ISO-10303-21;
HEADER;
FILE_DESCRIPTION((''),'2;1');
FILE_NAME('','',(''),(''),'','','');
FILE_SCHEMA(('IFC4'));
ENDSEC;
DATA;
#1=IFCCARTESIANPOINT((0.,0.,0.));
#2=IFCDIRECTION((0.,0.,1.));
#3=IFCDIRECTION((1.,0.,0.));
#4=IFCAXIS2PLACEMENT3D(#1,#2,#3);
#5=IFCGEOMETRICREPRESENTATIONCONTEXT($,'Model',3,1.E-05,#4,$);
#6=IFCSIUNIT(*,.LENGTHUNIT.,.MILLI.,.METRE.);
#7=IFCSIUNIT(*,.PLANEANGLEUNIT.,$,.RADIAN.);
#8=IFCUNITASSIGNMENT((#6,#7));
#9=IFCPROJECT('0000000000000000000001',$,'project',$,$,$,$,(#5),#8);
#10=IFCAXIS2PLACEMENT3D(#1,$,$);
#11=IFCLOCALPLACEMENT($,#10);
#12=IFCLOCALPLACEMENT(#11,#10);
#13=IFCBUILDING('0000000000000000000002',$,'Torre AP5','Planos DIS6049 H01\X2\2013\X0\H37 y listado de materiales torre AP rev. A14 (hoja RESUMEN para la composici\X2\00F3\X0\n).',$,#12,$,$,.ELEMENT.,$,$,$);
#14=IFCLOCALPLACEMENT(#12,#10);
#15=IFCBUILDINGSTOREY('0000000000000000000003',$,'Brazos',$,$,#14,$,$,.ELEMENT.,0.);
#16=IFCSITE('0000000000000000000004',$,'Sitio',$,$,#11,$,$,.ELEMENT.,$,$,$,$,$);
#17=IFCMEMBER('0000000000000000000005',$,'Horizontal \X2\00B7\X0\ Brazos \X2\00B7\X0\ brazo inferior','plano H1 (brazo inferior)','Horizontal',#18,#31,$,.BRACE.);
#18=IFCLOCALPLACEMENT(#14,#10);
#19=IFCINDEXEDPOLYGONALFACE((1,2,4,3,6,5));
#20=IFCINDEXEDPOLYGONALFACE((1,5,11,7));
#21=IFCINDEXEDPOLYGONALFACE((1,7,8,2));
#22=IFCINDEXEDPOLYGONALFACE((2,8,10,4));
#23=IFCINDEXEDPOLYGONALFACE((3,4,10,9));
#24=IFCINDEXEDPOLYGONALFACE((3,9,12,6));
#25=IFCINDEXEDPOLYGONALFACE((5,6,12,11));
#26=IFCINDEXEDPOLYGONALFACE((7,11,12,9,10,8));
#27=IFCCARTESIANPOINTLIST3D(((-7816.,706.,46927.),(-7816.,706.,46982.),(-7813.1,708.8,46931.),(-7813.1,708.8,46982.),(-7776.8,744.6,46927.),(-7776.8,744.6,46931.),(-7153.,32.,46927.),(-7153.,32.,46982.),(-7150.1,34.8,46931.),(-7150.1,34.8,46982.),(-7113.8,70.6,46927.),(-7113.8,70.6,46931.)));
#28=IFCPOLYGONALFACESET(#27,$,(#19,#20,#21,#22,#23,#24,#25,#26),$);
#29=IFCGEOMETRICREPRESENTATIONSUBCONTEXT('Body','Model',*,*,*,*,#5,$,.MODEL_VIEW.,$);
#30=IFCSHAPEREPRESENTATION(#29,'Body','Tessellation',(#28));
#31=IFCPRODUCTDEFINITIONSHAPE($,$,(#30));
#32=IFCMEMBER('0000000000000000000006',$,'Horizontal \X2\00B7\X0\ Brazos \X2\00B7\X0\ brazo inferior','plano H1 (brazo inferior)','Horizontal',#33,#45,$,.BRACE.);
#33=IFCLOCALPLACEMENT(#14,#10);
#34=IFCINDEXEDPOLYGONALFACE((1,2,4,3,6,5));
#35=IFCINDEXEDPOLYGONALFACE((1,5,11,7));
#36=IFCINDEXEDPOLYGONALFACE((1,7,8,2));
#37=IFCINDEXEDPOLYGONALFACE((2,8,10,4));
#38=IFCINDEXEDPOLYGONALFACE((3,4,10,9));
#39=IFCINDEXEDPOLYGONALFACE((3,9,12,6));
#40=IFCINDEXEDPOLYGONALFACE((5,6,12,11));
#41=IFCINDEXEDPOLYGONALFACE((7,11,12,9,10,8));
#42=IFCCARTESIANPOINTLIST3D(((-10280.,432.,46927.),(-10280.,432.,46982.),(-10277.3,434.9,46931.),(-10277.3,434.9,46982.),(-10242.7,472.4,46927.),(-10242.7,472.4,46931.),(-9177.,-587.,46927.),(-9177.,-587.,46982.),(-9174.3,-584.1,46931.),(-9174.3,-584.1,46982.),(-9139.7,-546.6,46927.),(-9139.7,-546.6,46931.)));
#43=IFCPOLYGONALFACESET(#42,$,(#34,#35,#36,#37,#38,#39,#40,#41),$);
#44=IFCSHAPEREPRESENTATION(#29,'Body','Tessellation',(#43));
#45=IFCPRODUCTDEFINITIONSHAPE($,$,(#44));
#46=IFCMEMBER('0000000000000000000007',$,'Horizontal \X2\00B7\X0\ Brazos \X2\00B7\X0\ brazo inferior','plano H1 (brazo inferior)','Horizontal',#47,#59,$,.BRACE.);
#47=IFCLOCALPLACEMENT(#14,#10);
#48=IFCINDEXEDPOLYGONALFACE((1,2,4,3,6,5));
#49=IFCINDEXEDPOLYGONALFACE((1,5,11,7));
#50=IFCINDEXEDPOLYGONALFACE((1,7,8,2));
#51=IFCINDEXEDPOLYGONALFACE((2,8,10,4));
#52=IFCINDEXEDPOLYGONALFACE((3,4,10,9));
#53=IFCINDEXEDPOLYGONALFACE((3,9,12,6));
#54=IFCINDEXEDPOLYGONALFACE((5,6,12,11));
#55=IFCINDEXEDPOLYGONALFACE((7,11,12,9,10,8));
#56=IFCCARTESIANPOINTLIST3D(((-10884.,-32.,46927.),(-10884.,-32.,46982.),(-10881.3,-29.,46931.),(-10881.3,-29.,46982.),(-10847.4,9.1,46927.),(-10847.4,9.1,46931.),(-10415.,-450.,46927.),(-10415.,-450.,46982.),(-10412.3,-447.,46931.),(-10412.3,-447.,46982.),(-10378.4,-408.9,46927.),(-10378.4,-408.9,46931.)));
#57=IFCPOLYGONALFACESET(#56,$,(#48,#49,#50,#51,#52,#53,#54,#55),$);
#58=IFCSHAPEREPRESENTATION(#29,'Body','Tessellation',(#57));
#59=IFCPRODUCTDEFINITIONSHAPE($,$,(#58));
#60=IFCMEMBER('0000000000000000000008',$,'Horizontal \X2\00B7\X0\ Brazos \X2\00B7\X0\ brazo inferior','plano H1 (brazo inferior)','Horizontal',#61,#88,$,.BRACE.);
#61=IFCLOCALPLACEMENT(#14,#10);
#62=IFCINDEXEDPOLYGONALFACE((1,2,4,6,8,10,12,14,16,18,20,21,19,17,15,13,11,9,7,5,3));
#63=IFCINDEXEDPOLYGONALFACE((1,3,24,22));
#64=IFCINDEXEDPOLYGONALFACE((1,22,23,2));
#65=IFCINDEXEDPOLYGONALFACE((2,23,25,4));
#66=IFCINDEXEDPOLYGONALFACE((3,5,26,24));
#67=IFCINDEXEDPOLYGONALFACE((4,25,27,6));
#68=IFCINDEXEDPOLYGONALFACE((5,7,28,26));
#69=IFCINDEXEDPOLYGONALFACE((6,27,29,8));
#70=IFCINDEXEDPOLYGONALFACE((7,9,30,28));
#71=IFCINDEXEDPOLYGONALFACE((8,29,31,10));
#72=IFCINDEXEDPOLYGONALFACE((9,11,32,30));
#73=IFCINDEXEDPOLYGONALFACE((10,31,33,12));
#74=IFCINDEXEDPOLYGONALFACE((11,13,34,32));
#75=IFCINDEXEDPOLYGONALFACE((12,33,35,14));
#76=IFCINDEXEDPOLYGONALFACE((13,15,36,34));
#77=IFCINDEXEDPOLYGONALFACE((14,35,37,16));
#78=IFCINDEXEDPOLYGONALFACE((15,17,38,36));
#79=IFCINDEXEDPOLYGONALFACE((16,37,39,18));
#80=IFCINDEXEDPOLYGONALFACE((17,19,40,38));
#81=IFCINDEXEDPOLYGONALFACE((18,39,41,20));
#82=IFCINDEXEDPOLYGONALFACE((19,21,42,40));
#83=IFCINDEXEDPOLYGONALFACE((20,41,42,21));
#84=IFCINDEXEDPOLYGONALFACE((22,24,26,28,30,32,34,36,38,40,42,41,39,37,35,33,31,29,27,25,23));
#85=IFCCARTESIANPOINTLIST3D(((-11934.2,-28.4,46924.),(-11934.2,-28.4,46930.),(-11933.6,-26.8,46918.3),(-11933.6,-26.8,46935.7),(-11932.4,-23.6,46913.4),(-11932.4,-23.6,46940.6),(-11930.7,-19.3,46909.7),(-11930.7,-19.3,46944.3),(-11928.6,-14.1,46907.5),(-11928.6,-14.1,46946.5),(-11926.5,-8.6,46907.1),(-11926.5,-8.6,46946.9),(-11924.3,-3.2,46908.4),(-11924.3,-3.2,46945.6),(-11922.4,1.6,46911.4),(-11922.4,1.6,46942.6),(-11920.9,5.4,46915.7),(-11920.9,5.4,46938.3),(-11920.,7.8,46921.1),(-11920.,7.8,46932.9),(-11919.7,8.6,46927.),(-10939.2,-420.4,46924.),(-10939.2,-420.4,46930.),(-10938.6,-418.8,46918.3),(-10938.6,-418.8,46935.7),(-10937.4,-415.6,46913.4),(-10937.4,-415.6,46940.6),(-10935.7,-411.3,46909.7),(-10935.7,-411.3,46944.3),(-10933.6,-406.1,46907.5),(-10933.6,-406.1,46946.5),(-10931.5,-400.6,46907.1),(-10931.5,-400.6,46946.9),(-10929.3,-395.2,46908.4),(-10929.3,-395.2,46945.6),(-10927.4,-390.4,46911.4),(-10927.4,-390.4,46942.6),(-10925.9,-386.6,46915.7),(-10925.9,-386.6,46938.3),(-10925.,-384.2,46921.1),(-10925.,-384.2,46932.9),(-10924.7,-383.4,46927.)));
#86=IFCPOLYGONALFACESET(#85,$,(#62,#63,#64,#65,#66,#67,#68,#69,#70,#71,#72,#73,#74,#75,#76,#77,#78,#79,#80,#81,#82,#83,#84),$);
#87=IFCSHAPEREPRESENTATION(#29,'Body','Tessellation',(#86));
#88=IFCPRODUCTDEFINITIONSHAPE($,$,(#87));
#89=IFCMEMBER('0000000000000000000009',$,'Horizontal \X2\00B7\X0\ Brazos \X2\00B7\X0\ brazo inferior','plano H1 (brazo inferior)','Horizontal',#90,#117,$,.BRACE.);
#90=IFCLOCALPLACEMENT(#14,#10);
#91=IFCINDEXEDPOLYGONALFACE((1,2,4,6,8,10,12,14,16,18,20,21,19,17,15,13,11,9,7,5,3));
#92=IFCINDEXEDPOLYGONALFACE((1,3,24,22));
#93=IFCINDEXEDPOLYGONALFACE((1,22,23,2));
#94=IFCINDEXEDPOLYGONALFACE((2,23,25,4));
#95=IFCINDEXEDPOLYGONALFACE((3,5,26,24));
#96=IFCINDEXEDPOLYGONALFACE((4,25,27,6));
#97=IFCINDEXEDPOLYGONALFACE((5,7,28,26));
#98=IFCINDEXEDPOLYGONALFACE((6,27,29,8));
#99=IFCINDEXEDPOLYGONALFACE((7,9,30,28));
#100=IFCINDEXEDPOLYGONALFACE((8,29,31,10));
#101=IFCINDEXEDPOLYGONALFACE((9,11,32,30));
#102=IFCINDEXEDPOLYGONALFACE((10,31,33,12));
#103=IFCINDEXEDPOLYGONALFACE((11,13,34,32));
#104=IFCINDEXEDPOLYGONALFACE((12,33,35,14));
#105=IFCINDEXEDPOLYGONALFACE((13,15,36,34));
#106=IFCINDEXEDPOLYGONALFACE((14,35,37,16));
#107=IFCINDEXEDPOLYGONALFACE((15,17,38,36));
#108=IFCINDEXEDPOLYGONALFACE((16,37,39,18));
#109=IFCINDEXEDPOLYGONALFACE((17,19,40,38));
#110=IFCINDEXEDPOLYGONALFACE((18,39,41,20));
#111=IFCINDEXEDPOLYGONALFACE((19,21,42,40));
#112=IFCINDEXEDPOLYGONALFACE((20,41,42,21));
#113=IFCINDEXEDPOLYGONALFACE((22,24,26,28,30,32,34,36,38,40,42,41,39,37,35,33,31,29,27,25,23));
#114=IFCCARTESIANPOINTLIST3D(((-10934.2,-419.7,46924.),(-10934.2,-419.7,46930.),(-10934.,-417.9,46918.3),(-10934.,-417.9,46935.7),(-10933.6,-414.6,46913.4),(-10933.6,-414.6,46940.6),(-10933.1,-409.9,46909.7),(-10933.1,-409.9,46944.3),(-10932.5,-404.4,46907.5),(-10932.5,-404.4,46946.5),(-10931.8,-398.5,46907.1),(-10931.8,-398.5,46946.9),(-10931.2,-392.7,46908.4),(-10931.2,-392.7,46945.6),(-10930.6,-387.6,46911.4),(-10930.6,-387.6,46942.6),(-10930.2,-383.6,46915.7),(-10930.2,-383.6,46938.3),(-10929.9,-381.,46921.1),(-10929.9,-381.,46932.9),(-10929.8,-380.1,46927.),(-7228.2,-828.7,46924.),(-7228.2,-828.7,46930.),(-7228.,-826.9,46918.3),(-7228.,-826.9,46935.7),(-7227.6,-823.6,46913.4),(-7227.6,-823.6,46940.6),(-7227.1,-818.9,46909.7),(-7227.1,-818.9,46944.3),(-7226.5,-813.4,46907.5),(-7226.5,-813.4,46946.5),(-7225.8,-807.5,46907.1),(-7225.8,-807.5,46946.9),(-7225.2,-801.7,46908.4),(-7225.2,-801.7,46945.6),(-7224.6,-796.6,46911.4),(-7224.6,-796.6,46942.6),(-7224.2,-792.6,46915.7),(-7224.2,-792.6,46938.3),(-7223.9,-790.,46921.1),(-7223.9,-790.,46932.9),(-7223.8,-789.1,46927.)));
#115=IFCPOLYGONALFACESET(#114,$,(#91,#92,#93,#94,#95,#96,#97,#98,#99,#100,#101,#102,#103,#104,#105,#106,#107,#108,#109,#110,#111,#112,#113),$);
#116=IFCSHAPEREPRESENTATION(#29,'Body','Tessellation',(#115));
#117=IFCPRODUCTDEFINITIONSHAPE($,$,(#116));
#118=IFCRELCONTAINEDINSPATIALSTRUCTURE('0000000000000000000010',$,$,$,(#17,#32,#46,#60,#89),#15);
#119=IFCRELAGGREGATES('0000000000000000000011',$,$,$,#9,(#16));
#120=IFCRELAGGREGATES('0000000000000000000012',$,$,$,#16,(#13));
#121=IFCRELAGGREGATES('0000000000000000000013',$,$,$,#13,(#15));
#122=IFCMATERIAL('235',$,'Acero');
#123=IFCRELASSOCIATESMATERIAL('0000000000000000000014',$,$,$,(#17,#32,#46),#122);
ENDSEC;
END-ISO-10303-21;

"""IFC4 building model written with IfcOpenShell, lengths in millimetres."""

from ifc_helpers import new_model, si_unit, frame, frame_2d, origin, origin_with_axes, place, context, subcontext, project, spatial, circle, l_section, extrude, material, element, save


model = new_model("IFC4")

# Units and contexts
model_context = context("Model", 3, precision=1e-05, world=origin_with_axes())
body_context = subcontext(model_context, "Body", "Model", "MODEL_VIEW")
ifc_project = project(units=[si_unit("LENGTHUNIT", "METRE", prefix="MILLI"), si_unit("PLANEANGLEUNIT", "RADIAN")], contexts=[model_context])

# Site, building, storey
site_placement = place(None, origin())
site = spatial("IfcSite", under=ifc_project, at=site_placement, Name="Sitio", CompositionType="ELEMENT")
building_placement = place(site_placement, origin())
building = spatial("IfcBuilding", under=site, at=building_placement, Name="Torre AP5", Description="Planos DIS6049 H01–H37 y listado de materiales torre AP rev. A14 (hoja RESUMEN para la composición).", CompositionType="ELEMENT")
storey_placement = place(building_placement, origin())
storey = spatial("IfcBuildingStorey", under=building, at=storey_placement, Name="Brazos", CompositionType="ELEMENT", Elevation=0.0)

# Members
ifc_material_1 = material(Name="235", Category="Acero")
member_1_placement = place(storey_placement, frame((-7816.0, 706.0, 46927.0), z_axis=(0.701265, -0.7129, 0.0), x_axis=(0.7129, 0.701265, 0.0)))
element("IfcMember", 1, at=member_1_placement, inside=storey, material=ifc_material_1, Name="Horizontal · Brazos · brazo inferior", Description="plano H1 (brazo inferior)", ObjectType="Horizontal", PredefinedType="BRACE", context=body_context, shape_type="SweptSolid", body=[
    extrude(l_section(Depth=55.0, Width=55.0, Thickness=4.0, at=frame_2d((27.5, 27.5))), None, (0.0, 0.0, 1.0), 945.4),
])
member_2_placement = place(storey_placement, frame((-10280.0, 432.0, 46927.0), z_axis=(0.734523, -0.678584, 0.0), x_axis=(0.678584, 0.734523, 0.0)))
element("IfcMember", 2, at=member_2_placement, inside=storey, material=ifc_material_1, Name="Horizontal · Brazos · brazo inferior", Description="plano H1 (brazo inferior)", ObjectType="Horizontal", PredefinedType="BRACE", context=body_context, shape_type="SweptSolid", body=[
    extrude(l_section(Depth=55.0, Width=55.0, Thickness=4.0, at=frame_2d((27.5, 27.5))), None, (0.0, 0.0, 1.0), 1501.7),
])
member_3_placement = place(storey_placement, frame((-10884.0, -32.0, 46927.0), z_axis=(0.74653, -0.665351, 0.0), x_axis=(0.665351, 0.74653, 0.0)))
element("IfcMember", 3, at=member_3_placement, inside=storey, material=ifc_material_1, Name="Horizontal · Brazos · brazo inferior", Description="plano H1 (brazo inferior)", ObjectType="Horizontal", PredefinedType="BRACE", context=body_context, shape_type="SweptSolid", body=[
    extrude(l_section(Depth=55.0, Width=55.0, Thickness=4.0, at=frame_2d((27.5, 27.5))), None, (0.0, 0.0, 1.0), 628.2),
])
member_4_placement = place(storey_placement, frame((-11927.0, -10.0, 46927.0), z_axis=(0.930399, -0.366549, 0.0), x_axis=(0.366549, 0.930399, 0.0)))
element("IfcMember", 4, at=member_4_placement, inside=storey, Name="Horizontal · Brazos · brazo inferior", Description="plano H1 (brazo inferior)", ObjectType="Horizontal", PredefinedType="BRACE", context=body_context, shape_type="SweptSolid", body=[
    extrude(circle(Radius=20.0), None, (0.0, 0.0, 1.0), 1069.4),
])
member_5_placement = place(storey_placement, frame((-10932.0, -400.0, 46927.0), z_axis=(0.993965, -0.109696, 0.0), x_axis=(0.109696, 0.993965, 0.0)))
element("IfcMember", 5, at=member_5_placement, inside=storey, Name="Horizontal · Brazos · brazo inferior", Description="plano H1 (brazo inferior)", ObjectType="Horizontal", PredefinedType="BRACE", context=body_context, shape_type="SweptSolid", body=[
    extrude(circle(Radius=20.0), None, (0.0, 0.0, 1.0), 3728.5),
])

save(model, "model.ifc")
